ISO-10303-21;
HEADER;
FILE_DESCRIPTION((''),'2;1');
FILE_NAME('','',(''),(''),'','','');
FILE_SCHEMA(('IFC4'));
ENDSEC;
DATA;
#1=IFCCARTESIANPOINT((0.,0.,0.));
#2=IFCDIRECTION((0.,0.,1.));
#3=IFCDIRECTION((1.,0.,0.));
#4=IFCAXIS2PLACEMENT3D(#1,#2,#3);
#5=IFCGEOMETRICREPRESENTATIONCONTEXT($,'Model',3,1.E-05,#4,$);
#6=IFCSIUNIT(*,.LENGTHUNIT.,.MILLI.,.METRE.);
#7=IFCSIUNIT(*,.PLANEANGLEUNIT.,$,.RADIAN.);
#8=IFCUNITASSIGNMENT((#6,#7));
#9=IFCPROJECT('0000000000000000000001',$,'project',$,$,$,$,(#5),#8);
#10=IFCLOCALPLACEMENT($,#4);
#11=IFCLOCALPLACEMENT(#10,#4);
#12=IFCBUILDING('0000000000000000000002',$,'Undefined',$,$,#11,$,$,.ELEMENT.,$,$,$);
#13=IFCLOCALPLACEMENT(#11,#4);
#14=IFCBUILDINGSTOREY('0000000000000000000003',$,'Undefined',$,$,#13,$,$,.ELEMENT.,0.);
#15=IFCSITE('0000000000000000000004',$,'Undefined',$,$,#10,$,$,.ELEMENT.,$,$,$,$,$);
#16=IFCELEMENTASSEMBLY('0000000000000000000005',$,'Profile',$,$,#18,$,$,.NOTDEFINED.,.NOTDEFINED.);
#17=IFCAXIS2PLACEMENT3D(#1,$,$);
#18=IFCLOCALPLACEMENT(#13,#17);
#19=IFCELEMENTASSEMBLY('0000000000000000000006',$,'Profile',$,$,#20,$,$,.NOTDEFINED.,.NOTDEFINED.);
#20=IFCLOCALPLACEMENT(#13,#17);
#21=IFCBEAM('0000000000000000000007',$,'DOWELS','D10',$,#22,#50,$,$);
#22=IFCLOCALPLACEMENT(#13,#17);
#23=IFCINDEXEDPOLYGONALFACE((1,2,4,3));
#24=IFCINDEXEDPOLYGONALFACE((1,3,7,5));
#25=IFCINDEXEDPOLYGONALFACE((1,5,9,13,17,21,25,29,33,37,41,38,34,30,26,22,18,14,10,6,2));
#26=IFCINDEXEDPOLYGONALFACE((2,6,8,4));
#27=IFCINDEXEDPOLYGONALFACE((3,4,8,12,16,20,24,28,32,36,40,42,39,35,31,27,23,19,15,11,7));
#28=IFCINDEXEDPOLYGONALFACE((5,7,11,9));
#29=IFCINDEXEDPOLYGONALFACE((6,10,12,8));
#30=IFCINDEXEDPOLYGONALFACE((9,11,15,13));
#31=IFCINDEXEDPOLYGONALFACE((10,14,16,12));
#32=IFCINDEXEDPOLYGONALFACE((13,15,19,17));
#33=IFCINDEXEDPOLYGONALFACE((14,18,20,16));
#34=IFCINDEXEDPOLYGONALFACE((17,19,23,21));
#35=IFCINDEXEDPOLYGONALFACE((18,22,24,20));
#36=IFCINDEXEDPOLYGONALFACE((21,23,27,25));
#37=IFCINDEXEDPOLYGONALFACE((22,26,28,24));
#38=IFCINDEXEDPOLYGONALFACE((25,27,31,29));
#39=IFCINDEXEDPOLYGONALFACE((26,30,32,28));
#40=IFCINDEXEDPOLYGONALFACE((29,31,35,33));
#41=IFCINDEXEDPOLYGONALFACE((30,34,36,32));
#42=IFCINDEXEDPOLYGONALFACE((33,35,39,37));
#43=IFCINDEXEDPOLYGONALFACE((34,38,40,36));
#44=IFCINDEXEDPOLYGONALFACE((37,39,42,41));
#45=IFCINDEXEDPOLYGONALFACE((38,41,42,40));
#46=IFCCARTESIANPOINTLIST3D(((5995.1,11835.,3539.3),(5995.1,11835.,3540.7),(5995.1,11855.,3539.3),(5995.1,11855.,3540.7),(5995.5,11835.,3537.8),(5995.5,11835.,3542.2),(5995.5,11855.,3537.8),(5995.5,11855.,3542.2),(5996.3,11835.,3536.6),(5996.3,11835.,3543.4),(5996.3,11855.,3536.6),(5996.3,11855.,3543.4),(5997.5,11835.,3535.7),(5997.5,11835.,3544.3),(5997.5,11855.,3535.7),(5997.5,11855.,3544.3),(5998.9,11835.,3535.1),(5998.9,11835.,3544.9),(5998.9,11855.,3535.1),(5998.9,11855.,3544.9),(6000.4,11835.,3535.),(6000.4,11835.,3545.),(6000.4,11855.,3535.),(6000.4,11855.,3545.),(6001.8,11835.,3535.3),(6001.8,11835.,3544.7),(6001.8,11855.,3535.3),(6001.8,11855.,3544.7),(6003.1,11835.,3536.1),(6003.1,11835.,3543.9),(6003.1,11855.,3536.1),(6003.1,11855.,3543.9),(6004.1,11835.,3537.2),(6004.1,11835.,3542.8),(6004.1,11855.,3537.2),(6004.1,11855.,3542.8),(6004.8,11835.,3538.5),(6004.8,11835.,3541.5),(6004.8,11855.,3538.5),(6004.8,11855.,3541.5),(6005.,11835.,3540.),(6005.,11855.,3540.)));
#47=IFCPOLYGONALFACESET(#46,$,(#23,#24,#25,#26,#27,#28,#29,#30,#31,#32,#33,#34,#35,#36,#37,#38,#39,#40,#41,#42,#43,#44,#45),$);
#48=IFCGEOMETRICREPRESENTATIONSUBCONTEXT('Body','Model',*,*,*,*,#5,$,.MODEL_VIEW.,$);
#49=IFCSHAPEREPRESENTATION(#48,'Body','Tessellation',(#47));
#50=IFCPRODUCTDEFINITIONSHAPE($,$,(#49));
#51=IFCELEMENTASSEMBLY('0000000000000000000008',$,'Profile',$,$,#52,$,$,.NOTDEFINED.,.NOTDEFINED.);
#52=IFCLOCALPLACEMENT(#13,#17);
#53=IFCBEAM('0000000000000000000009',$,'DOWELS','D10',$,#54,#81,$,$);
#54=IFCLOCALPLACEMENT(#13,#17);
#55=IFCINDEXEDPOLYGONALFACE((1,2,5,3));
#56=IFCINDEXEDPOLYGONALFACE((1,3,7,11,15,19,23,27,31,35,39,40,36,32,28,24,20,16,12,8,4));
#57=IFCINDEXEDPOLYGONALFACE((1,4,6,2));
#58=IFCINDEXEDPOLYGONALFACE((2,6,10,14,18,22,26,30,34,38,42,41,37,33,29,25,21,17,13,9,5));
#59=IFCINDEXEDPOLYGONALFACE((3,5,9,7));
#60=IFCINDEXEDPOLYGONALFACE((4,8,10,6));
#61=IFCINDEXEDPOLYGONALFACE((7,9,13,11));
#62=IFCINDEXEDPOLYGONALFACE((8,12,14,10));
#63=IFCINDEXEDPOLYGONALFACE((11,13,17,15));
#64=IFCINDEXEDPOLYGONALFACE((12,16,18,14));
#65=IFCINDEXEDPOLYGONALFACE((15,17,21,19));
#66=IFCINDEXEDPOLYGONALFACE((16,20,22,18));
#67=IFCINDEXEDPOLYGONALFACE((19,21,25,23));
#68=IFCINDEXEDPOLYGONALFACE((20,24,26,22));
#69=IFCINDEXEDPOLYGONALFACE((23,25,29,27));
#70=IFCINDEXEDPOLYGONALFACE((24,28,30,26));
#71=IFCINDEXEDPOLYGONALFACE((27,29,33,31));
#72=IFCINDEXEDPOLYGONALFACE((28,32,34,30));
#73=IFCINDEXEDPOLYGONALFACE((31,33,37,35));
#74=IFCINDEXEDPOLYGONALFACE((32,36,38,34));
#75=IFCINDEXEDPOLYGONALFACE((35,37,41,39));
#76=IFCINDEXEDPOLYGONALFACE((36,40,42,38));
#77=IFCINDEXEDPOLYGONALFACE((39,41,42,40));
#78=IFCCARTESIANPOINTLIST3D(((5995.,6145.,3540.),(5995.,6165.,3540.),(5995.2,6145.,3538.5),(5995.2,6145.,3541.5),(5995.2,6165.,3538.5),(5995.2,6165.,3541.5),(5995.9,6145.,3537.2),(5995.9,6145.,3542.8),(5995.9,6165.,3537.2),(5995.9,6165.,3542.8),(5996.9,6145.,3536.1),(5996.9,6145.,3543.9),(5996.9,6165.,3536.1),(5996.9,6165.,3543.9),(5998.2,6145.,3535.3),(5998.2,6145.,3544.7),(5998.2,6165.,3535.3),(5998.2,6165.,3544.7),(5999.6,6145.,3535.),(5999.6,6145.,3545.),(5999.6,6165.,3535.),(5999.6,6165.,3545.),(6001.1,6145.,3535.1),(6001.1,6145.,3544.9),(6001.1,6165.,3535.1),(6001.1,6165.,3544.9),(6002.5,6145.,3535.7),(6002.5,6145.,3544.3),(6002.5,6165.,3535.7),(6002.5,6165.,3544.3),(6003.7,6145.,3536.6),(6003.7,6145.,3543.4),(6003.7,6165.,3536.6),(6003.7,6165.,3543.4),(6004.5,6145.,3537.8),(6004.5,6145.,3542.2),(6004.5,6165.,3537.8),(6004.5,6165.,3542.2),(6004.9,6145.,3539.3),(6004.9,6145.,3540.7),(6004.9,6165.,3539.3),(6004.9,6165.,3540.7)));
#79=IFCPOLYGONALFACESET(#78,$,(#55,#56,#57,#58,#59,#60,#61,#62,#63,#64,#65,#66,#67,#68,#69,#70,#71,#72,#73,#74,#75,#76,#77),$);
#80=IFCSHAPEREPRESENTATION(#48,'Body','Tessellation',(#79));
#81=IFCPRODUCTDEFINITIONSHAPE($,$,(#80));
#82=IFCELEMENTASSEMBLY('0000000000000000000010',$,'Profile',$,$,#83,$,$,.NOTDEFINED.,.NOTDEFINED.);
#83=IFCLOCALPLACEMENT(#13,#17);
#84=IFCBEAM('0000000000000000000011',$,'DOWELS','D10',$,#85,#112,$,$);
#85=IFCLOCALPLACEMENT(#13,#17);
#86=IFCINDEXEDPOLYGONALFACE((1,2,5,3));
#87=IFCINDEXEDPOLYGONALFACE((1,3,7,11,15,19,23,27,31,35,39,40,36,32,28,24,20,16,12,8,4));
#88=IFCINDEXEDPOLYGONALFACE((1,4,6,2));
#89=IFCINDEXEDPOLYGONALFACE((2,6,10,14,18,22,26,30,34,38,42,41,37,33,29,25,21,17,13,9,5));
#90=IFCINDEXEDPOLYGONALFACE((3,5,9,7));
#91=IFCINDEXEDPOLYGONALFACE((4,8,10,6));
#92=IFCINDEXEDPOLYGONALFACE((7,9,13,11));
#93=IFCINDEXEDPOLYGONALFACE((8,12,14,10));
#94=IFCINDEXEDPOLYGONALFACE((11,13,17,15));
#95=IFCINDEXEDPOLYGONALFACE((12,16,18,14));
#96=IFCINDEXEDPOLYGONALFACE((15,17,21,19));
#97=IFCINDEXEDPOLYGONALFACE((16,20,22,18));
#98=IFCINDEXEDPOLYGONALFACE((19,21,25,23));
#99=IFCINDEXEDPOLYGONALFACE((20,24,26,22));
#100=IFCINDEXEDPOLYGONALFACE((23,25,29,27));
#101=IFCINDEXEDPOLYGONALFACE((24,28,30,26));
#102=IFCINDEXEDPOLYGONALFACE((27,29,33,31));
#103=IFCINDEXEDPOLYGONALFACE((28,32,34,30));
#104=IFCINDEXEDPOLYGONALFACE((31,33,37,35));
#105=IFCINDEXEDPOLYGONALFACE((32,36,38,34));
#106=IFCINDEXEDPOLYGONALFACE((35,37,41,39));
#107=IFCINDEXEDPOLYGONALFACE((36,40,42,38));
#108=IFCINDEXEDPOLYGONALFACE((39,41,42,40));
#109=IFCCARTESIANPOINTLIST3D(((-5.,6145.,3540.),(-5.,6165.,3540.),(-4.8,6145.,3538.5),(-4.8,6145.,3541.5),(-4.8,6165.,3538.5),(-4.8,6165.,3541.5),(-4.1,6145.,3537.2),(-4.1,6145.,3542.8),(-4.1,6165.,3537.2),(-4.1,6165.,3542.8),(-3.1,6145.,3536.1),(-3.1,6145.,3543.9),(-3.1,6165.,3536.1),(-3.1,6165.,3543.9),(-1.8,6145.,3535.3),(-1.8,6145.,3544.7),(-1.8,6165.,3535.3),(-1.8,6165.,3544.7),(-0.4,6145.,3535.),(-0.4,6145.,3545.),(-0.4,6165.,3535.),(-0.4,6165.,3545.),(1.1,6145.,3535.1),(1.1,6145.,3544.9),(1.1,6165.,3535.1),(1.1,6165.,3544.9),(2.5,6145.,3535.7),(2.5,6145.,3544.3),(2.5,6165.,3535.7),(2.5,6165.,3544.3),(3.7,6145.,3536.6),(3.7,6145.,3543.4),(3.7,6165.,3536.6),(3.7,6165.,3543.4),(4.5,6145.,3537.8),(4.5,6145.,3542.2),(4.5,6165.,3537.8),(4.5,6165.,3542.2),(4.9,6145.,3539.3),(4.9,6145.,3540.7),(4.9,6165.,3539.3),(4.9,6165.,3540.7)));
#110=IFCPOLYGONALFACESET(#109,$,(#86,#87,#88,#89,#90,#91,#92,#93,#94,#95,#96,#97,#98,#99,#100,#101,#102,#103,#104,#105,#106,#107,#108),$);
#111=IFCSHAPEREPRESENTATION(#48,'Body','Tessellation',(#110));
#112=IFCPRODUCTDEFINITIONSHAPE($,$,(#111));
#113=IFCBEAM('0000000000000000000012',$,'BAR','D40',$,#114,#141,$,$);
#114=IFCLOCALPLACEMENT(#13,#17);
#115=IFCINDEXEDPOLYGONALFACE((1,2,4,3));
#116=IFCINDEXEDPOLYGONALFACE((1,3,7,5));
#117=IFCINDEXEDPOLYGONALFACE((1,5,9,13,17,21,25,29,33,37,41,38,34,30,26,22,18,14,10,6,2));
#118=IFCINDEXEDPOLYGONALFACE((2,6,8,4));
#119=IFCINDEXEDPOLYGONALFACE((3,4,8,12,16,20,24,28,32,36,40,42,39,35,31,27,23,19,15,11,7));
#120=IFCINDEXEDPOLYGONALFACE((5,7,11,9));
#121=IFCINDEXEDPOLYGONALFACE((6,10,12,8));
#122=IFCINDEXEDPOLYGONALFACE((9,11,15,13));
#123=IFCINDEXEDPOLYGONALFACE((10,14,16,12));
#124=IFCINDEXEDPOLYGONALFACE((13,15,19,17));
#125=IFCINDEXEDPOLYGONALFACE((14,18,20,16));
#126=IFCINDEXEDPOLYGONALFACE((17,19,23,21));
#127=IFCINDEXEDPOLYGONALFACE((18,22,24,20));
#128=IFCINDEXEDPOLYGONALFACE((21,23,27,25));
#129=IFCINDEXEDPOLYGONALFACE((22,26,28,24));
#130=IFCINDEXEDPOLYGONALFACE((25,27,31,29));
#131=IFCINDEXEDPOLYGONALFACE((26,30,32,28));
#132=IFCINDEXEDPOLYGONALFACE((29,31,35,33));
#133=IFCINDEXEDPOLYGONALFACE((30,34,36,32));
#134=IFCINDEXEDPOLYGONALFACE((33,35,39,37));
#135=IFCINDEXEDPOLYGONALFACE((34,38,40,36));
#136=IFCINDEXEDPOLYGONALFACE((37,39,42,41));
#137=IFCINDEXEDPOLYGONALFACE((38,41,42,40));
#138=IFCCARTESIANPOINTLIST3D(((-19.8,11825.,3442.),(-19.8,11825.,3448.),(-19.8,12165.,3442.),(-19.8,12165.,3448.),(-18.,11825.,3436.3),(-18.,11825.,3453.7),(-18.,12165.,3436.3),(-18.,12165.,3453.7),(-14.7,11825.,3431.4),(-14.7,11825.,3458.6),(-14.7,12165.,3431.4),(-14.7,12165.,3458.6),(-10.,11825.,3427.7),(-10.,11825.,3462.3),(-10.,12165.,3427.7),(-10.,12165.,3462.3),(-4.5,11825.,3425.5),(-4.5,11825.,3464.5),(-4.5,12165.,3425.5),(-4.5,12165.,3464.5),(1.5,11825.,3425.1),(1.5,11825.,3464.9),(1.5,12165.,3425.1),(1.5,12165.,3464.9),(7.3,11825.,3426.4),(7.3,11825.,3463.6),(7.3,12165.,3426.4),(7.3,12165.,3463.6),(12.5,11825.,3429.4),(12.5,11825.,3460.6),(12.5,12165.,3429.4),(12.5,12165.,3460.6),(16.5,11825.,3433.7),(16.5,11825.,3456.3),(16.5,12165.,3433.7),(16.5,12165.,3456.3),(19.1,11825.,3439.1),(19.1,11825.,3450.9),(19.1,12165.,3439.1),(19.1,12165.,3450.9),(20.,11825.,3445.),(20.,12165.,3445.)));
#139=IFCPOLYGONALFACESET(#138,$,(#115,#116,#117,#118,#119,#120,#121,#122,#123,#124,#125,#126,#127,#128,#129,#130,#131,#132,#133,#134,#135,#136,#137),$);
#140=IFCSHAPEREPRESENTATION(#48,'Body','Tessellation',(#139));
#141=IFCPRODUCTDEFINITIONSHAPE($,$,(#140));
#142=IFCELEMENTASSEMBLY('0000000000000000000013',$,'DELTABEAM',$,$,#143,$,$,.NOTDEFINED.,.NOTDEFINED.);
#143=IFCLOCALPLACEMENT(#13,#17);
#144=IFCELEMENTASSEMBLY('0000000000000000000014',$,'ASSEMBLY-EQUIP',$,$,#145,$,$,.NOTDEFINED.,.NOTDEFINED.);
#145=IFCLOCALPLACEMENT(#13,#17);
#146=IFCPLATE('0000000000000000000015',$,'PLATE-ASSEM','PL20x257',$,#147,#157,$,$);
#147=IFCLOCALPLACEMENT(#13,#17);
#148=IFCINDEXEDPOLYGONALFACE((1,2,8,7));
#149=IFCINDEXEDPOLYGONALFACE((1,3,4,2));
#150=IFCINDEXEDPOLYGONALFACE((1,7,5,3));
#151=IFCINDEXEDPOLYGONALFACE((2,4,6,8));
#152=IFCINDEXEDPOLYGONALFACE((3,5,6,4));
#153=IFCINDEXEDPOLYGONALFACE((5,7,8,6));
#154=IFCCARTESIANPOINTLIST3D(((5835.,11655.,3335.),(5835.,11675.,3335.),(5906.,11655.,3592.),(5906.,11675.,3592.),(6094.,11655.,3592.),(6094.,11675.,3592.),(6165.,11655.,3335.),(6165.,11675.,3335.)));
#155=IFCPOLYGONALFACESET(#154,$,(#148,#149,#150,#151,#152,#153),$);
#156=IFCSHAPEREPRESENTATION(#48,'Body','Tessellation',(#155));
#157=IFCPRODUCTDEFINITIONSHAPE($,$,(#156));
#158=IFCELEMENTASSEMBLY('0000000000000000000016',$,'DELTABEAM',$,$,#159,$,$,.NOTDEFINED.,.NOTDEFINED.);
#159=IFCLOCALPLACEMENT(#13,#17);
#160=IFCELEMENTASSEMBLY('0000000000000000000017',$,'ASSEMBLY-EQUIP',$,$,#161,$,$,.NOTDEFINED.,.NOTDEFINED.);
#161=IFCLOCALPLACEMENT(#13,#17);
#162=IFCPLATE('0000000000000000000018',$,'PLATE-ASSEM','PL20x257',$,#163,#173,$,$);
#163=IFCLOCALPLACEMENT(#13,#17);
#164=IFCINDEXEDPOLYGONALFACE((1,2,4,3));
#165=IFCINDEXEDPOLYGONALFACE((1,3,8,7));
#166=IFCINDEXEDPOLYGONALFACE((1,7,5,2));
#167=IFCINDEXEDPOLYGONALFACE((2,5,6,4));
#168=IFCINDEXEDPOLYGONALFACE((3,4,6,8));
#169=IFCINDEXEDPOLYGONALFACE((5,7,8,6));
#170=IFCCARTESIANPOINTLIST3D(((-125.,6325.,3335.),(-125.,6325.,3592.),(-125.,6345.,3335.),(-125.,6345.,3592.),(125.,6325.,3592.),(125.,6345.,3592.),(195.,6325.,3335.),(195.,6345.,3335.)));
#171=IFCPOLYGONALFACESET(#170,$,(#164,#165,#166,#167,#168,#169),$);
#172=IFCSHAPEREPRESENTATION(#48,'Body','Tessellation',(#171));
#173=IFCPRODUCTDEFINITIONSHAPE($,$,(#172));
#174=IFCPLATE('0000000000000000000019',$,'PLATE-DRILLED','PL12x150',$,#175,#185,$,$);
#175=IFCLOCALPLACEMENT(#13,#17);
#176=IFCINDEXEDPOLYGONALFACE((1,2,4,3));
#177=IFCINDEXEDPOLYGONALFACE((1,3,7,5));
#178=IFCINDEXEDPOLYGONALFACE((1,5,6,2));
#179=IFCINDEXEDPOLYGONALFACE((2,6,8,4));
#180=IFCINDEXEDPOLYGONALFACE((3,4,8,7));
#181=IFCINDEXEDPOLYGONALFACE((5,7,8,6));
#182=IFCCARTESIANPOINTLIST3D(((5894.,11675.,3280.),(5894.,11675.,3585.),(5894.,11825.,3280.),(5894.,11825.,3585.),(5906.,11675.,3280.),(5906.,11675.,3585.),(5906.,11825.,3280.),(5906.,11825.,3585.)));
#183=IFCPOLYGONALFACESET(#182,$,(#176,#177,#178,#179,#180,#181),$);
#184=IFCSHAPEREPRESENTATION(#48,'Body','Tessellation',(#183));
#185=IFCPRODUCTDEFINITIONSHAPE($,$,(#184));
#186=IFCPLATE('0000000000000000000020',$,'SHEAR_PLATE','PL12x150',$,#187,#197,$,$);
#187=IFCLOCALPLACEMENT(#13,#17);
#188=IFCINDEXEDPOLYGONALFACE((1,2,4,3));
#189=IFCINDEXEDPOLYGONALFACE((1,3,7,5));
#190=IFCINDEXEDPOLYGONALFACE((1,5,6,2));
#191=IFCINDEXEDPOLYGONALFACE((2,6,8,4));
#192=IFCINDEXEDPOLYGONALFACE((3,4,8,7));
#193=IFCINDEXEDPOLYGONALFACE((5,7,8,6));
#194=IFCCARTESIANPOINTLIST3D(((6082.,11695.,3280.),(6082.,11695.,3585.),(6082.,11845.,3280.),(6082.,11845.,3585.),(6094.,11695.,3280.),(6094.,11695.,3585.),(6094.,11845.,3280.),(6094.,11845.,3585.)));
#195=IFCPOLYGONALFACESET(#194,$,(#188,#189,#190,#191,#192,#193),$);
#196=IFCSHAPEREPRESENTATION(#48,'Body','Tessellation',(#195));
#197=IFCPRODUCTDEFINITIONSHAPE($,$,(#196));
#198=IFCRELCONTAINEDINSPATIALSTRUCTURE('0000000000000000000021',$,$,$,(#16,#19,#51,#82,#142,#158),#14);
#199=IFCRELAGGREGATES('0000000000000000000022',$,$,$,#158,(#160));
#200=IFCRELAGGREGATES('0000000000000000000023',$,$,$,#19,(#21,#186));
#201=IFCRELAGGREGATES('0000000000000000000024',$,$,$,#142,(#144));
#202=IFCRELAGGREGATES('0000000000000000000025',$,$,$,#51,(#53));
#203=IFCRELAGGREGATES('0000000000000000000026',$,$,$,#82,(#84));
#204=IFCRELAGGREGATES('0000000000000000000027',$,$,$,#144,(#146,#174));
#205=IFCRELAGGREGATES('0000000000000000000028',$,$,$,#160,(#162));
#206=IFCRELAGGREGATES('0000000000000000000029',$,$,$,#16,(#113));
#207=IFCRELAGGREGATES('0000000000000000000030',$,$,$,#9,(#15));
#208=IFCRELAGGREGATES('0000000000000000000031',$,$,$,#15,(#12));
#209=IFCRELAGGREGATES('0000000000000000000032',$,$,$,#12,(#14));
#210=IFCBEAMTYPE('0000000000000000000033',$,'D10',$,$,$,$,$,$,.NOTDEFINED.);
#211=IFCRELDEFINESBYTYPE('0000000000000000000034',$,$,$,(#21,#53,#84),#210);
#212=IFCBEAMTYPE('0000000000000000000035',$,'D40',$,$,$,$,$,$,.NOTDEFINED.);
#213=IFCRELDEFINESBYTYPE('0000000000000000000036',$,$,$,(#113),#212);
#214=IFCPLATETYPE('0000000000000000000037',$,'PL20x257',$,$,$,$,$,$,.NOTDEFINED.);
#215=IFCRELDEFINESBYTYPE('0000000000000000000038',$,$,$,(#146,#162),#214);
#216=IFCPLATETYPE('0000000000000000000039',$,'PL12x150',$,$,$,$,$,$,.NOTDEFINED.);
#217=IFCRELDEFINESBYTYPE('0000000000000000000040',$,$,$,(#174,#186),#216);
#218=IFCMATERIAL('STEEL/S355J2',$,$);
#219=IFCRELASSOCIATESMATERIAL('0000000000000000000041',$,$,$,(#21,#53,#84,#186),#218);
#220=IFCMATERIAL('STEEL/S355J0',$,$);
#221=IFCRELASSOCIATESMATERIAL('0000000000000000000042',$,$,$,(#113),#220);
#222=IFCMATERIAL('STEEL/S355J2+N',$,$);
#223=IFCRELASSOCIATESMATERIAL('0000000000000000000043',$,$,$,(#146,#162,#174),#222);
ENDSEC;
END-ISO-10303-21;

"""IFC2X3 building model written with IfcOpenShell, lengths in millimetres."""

from ifc_helpers import new_model, si_unit, frame, origin_with_axes, origin_2d_with_axis, place, context, subcontext, project, spatial, polyline, circle, outline, extrude, material, type_object, element, aggregate, save


model = new_model("IFC2X3")

# Units and contexts
model_context = context("Model", 3, precision=1e-05, world=origin_with_axes())
body_context = subcontext(model_context, "Body", "Model", "MODEL_VIEW")
ifc_project = project(units=[si_unit("LENGTHUNIT", "METRE", prefix="MILLI"), si_unit("PLANEANGLEUNIT", "RADIAN")], contexts=[model_context])

# Site, building, storey
site_placement = place(None, origin_with_axes())
site = spatial("IfcSite", under=ifc_project, at=site_placement, Name="Undefined", CompositionType="ELEMENT")
building_placement = place(site_placement, origin_with_axes())
building = spatial("IfcBuilding", under=site, at=building_placement, Name="Undefined", CompositionType="ELEMENT")
storey_placement = place(building_placement, origin_with_axes())
storey = spatial("IfcBuildingStorey", under=building, at=storey_placement, Name="Undefined", CompositionType="ELEMENT", Elevation=0.0)

# Element assembly
assembly_1_placement = place(storey_placement, origin_with_axes())
assembly_1 = element("IfcElementAssembly", 1, at=assembly_1_placement, inside=storey, Name="Profile", AssemblyPlace="NOTDEFINED", PredefinedType="NOTDEFINED")

# Element assemblies, beams
assembly_2_placement = place(storey_placement, origin_with_axes())
assembly_2 = element("IfcElementAssembly", 2, at=assembly_2_placement, inside=storey, Name="Profile", AssemblyPlace="NOTDEFINED", PredefinedType="NOTDEFINED")
ifc_material_1 = material(Name="STEEL/S355J2")
beam_type_1 = type_object("IfcBeamType", Name="D10", PredefinedType="NOTDEFINED")
beam_1_placement = place(assembly_2_placement, frame((6000.0, 11835.0, 3540.0), z_axis=(0.0, 0.0, 1.0), x_axis=(0.0, 1.0, 0.0)))
beam_1 = element("IfcBeam", 3, at=beam_1_placement, type_object=beam_type_1, material=ifc_material_1, Name="DOWELS", Description="D10", context=body_context, shape_type="SweptSolid", body=[
    extrude(circle(Radius=5.0, at=origin_2d_with_axis()), frame((20.0, 0.0, 0.0), z_axis=(-1.0, 0.0, 0.0), x_axis=(0.0, -1.0, 0.0)), (0.0, 0.0, 1.0), 20.0),
])
assembly_3_placement = place(storey_placement, origin_with_axes())
assembly_3 = element("IfcElementAssembly", 4, at=assembly_3_placement, inside=storey, Name="Profile", AssemblyPlace="NOTDEFINED", PredefinedType="NOTDEFINED")
beam_2_placement = place(assembly_3_placement, frame((6000.0, 6165.0, 3540.0), z_axis=(0.0, 0.0, 1.0), x_axis=(0.0, -1.0, 0.0)))
beam_2 = element("IfcBeam", 5, at=beam_2_placement, type_object=beam_type_1, material=ifc_material_1, Name="DOWELS", Description="D10", context=body_context, shape_type="SweptSolid", body=[
    extrude(circle(Radius=5.0, at=origin_2d_with_axis()), frame((20.0, 0.0, 0.0), z_axis=(-1.0, 0.0, 0.0), x_axis=(0.0, -1.0, 0.0)), (0.0, 0.0, 1.0), 20.0),
])
assembly_4_placement = place(storey_placement, origin_with_axes())
assembly_4 = element("IfcElementAssembly", 6, at=assembly_4_placement, inside=storey, Name="Profile", AssemblyPlace="NOTDEFINED", PredefinedType="NOTDEFINED")
beam_3_placement = place(assembly_4_placement, frame((0.0, 6165.0, 3540.0), z_axis=(0.0, 0.0, 1.0), x_axis=(0.0, -1.0, 0.0)))
beam_3 = element("IfcBeam", 7, at=beam_3_placement, type_object=beam_type_1, material=ifc_material_1, Name="DOWELS", Description="D10", context=body_context, shape_type="SweptSolid", body=[
    extrude(circle(Radius=5.0, at=origin_2d_with_axis()), frame((20.0, 0.0, 0.0), z_axis=(-1.0, 0.0, 0.0), x_axis=(0.0, -1.0, 0.0)), (0.0, 0.0, 1.0), 20.0),
])

# Beam
ifc_material_2 = material(Name="STEEL/S355J0")
beam_type_2 = type_object("IfcBeamType", Name="D40", PredefinedType="NOTDEFINED")
beam_4_placement = place(assembly_1_placement, frame((0.0, 11825.0, 3445.0), z_axis=(0.0, 0.0, 1.0), x_axis=(0.0, 1.0, 0.0)))
beam_4 = element("IfcBeam", 8, at=beam_4_placement, type_object=beam_type_2, material=ifc_material_2, Name="BAR", Description="D40", context=body_context, shape_type="SweptSolid", body=[
    extrude(circle(Radius=20.0, at=origin_2d_with_axis()), frame((340.0, 0.0, 0.0), z_axis=(-1.0, 0.0, 0.0), x_axis=(0.0, -1.0, 0.0)), (0.0, 0.0, 1.0), 340.0),
])

# Element assemblies, plate
assembly_5_placement = place(storey_placement, origin_with_axes())
assembly_5 = element("IfcElementAssembly", 9, at=assembly_5_placement, inside=storey, Name="DELTABEAM", AssemblyPlace="NOTDEFINED", PredefinedType="NOTDEFINED")
assembly_6_placement = place(assembly_5_placement, origin_with_axes())
assembly_6 = element("IfcElementAssembly", 10, at=assembly_6_placement, Name="ASSEMBLY-EQUIP", AssemblyPlace="NOTDEFINED", PredefinedType="NOTDEFINED")
ifc_material_3 = material(Name="STEEL/S355J2+N")
plate_type_1 = type_object("IfcPlateType", Name="PL20x257", PredefinedType="NOTDEFINED")
plate_1_placement = place(assembly_6_placement, frame((5835.0, 11665.0, 3335.0), z_axis=(0.0, -1.0, 0.0), x_axis=(1.0, 0.0, 0.0)))
plate_1 = element("IfcPlate", 11, at=plate_1_placement, type_object=plate_type_1, material=ifc_material_3, Name="PLATE-ASSEM", Description="PL20x257", context=body_context, shape_type="SweptSolid", body=[
    extrude(outline(polyline([(0.0, 0.0), (330.0, 0.0), (259.0, 257.0), (71.0, 257.0), (0.0, 0.0)])), frame((0.0, 0.0, -10.0), z_axis=(0.0, 0.0, 1.0), x_axis=(1.0, 0.0, 0.0)), (0.0, 0.0, 1.0), 20.0),
])

# Element assemblies, plate
assembly_7_placement = place(storey_placement, origin_with_axes())
assembly_7 = element("IfcElementAssembly", 12, at=assembly_7_placement, inside=storey, Name="DELTABEAM", AssemblyPlace="NOTDEFINED", PredefinedType="NOTDEFINED")
assembly_8_placement = place(assembly_7_placement, origin_with_axes())
assembly_8 = element("IfcElementAssembly", 13, at=assembly_8_placement, Name="ASSEMBLY-EQUIP", AssemblyPlace="NOTDEFINED", PredefinedType="NOTDEFINED")
plate_2_placement = place(assembly_8_placement, frame((195.0, 6335.0, 3335.0), z_axis=(0.0, 1.0, 0.0), x_axis=(-1.0, 0.0, 0.0)))
plate_2 = element("IfcPlate", 14, at=plate_2_placement, type_object=plate_type_1, material=ifc_material_3, Name="PLATE-ASSEM", Description="PL20x257", context=body_context, shape_type="SweptSolid", body=[
    extrude(outline(polyline([(0.0, 0.0), (320.0, 0.0), (320.0, 257.0), (70.0, 257.0), (0.0, 0.0)])), frame((0.0, 0.0, -10.0), z_axis=(0.0, 0.0, 1.0), x_axis=(1.0, 0.0, 0.0)), (0.0, 0.0, 1.0), 20.0),
])
aggregate(assembly_7, [assembly_8])

# Plates
plate_type_2 = type_object("IfcPlateType", Name="PL12x150", PredefinedType="NOTDEFINED")
plate_3_placement = place(assembly_6_placement, frame((5900.0, 11675.0, 3585.0), z_axis=(-1.0, 0.0, 0.0), x_axis=(0.0, 1.0, 0.0)))
plate_3 = element("IfcPlate", 15, at=plate_3_placement, type_object=plate_type_2, material=ifc_material_3, Name="PLATE-DRILLED", Description="PL12x150", context=body_context, shape_type="SweptSolid", body=[
    extrude(outline(polyline([(0.0, 0.0), (150.0, 0.0), (150.0, 0.0), (150.0, 305.0), (150.0, 305.0), (0.0, 305.0), (0.0, 305.0), (0.0, 0.0)])), frame((0.0, 0.0, -6.0), z_axis=(0.0, 0.0, 1.0), x_axis=(1.0, 0.0, 0.0)), (0.0, 0.0, 1.0), 12.0),
])
plate_4_placement = place(assembly_2_placement, frame((6088.0, 11845.0, 3585.0), z_axis=(1.0, 0.0, 0.0), x_axis=(0.0, -1.0, 0.0)))
plate_4 = element("IfcPlate", 16, at=plate_4_placement, type_object=plate_type_2, material=ifc_material_1, Name="SHEAR_PLATE", Description="PL12x150", context=body_context, shape_type="SweptSolid", body=[
    extrude(outline(polyline([(0.0, 0.0), (150.0, 0.0), (150.0, 0.0), (150.0, 305.0), (150.0, 305.0), (0.0, 305.0), (0.0, 305.0), (0.0, 0.0)])), frame((0.0, 0.0, -6.0), z_axis=(0.0, 0.0, 1.0), x_axis=(1.0, 0.0, 0.0)), (0.0, 0.0, 1.0), 12.0),
])
aggregate(assembly_2, [beam_1, plate_4])

aggregate(assembly_5, [assembly_6])

aggregate(assembly_3, [beam_2])
aggregate(assembly_4, [beam_3])

aggregate(assembly_6, [plate_1, plate_3])
aggregate(assembly_8, [plate_2])
aggregate(assembly_1, [beam_4])

save(model, "model.ifc")
